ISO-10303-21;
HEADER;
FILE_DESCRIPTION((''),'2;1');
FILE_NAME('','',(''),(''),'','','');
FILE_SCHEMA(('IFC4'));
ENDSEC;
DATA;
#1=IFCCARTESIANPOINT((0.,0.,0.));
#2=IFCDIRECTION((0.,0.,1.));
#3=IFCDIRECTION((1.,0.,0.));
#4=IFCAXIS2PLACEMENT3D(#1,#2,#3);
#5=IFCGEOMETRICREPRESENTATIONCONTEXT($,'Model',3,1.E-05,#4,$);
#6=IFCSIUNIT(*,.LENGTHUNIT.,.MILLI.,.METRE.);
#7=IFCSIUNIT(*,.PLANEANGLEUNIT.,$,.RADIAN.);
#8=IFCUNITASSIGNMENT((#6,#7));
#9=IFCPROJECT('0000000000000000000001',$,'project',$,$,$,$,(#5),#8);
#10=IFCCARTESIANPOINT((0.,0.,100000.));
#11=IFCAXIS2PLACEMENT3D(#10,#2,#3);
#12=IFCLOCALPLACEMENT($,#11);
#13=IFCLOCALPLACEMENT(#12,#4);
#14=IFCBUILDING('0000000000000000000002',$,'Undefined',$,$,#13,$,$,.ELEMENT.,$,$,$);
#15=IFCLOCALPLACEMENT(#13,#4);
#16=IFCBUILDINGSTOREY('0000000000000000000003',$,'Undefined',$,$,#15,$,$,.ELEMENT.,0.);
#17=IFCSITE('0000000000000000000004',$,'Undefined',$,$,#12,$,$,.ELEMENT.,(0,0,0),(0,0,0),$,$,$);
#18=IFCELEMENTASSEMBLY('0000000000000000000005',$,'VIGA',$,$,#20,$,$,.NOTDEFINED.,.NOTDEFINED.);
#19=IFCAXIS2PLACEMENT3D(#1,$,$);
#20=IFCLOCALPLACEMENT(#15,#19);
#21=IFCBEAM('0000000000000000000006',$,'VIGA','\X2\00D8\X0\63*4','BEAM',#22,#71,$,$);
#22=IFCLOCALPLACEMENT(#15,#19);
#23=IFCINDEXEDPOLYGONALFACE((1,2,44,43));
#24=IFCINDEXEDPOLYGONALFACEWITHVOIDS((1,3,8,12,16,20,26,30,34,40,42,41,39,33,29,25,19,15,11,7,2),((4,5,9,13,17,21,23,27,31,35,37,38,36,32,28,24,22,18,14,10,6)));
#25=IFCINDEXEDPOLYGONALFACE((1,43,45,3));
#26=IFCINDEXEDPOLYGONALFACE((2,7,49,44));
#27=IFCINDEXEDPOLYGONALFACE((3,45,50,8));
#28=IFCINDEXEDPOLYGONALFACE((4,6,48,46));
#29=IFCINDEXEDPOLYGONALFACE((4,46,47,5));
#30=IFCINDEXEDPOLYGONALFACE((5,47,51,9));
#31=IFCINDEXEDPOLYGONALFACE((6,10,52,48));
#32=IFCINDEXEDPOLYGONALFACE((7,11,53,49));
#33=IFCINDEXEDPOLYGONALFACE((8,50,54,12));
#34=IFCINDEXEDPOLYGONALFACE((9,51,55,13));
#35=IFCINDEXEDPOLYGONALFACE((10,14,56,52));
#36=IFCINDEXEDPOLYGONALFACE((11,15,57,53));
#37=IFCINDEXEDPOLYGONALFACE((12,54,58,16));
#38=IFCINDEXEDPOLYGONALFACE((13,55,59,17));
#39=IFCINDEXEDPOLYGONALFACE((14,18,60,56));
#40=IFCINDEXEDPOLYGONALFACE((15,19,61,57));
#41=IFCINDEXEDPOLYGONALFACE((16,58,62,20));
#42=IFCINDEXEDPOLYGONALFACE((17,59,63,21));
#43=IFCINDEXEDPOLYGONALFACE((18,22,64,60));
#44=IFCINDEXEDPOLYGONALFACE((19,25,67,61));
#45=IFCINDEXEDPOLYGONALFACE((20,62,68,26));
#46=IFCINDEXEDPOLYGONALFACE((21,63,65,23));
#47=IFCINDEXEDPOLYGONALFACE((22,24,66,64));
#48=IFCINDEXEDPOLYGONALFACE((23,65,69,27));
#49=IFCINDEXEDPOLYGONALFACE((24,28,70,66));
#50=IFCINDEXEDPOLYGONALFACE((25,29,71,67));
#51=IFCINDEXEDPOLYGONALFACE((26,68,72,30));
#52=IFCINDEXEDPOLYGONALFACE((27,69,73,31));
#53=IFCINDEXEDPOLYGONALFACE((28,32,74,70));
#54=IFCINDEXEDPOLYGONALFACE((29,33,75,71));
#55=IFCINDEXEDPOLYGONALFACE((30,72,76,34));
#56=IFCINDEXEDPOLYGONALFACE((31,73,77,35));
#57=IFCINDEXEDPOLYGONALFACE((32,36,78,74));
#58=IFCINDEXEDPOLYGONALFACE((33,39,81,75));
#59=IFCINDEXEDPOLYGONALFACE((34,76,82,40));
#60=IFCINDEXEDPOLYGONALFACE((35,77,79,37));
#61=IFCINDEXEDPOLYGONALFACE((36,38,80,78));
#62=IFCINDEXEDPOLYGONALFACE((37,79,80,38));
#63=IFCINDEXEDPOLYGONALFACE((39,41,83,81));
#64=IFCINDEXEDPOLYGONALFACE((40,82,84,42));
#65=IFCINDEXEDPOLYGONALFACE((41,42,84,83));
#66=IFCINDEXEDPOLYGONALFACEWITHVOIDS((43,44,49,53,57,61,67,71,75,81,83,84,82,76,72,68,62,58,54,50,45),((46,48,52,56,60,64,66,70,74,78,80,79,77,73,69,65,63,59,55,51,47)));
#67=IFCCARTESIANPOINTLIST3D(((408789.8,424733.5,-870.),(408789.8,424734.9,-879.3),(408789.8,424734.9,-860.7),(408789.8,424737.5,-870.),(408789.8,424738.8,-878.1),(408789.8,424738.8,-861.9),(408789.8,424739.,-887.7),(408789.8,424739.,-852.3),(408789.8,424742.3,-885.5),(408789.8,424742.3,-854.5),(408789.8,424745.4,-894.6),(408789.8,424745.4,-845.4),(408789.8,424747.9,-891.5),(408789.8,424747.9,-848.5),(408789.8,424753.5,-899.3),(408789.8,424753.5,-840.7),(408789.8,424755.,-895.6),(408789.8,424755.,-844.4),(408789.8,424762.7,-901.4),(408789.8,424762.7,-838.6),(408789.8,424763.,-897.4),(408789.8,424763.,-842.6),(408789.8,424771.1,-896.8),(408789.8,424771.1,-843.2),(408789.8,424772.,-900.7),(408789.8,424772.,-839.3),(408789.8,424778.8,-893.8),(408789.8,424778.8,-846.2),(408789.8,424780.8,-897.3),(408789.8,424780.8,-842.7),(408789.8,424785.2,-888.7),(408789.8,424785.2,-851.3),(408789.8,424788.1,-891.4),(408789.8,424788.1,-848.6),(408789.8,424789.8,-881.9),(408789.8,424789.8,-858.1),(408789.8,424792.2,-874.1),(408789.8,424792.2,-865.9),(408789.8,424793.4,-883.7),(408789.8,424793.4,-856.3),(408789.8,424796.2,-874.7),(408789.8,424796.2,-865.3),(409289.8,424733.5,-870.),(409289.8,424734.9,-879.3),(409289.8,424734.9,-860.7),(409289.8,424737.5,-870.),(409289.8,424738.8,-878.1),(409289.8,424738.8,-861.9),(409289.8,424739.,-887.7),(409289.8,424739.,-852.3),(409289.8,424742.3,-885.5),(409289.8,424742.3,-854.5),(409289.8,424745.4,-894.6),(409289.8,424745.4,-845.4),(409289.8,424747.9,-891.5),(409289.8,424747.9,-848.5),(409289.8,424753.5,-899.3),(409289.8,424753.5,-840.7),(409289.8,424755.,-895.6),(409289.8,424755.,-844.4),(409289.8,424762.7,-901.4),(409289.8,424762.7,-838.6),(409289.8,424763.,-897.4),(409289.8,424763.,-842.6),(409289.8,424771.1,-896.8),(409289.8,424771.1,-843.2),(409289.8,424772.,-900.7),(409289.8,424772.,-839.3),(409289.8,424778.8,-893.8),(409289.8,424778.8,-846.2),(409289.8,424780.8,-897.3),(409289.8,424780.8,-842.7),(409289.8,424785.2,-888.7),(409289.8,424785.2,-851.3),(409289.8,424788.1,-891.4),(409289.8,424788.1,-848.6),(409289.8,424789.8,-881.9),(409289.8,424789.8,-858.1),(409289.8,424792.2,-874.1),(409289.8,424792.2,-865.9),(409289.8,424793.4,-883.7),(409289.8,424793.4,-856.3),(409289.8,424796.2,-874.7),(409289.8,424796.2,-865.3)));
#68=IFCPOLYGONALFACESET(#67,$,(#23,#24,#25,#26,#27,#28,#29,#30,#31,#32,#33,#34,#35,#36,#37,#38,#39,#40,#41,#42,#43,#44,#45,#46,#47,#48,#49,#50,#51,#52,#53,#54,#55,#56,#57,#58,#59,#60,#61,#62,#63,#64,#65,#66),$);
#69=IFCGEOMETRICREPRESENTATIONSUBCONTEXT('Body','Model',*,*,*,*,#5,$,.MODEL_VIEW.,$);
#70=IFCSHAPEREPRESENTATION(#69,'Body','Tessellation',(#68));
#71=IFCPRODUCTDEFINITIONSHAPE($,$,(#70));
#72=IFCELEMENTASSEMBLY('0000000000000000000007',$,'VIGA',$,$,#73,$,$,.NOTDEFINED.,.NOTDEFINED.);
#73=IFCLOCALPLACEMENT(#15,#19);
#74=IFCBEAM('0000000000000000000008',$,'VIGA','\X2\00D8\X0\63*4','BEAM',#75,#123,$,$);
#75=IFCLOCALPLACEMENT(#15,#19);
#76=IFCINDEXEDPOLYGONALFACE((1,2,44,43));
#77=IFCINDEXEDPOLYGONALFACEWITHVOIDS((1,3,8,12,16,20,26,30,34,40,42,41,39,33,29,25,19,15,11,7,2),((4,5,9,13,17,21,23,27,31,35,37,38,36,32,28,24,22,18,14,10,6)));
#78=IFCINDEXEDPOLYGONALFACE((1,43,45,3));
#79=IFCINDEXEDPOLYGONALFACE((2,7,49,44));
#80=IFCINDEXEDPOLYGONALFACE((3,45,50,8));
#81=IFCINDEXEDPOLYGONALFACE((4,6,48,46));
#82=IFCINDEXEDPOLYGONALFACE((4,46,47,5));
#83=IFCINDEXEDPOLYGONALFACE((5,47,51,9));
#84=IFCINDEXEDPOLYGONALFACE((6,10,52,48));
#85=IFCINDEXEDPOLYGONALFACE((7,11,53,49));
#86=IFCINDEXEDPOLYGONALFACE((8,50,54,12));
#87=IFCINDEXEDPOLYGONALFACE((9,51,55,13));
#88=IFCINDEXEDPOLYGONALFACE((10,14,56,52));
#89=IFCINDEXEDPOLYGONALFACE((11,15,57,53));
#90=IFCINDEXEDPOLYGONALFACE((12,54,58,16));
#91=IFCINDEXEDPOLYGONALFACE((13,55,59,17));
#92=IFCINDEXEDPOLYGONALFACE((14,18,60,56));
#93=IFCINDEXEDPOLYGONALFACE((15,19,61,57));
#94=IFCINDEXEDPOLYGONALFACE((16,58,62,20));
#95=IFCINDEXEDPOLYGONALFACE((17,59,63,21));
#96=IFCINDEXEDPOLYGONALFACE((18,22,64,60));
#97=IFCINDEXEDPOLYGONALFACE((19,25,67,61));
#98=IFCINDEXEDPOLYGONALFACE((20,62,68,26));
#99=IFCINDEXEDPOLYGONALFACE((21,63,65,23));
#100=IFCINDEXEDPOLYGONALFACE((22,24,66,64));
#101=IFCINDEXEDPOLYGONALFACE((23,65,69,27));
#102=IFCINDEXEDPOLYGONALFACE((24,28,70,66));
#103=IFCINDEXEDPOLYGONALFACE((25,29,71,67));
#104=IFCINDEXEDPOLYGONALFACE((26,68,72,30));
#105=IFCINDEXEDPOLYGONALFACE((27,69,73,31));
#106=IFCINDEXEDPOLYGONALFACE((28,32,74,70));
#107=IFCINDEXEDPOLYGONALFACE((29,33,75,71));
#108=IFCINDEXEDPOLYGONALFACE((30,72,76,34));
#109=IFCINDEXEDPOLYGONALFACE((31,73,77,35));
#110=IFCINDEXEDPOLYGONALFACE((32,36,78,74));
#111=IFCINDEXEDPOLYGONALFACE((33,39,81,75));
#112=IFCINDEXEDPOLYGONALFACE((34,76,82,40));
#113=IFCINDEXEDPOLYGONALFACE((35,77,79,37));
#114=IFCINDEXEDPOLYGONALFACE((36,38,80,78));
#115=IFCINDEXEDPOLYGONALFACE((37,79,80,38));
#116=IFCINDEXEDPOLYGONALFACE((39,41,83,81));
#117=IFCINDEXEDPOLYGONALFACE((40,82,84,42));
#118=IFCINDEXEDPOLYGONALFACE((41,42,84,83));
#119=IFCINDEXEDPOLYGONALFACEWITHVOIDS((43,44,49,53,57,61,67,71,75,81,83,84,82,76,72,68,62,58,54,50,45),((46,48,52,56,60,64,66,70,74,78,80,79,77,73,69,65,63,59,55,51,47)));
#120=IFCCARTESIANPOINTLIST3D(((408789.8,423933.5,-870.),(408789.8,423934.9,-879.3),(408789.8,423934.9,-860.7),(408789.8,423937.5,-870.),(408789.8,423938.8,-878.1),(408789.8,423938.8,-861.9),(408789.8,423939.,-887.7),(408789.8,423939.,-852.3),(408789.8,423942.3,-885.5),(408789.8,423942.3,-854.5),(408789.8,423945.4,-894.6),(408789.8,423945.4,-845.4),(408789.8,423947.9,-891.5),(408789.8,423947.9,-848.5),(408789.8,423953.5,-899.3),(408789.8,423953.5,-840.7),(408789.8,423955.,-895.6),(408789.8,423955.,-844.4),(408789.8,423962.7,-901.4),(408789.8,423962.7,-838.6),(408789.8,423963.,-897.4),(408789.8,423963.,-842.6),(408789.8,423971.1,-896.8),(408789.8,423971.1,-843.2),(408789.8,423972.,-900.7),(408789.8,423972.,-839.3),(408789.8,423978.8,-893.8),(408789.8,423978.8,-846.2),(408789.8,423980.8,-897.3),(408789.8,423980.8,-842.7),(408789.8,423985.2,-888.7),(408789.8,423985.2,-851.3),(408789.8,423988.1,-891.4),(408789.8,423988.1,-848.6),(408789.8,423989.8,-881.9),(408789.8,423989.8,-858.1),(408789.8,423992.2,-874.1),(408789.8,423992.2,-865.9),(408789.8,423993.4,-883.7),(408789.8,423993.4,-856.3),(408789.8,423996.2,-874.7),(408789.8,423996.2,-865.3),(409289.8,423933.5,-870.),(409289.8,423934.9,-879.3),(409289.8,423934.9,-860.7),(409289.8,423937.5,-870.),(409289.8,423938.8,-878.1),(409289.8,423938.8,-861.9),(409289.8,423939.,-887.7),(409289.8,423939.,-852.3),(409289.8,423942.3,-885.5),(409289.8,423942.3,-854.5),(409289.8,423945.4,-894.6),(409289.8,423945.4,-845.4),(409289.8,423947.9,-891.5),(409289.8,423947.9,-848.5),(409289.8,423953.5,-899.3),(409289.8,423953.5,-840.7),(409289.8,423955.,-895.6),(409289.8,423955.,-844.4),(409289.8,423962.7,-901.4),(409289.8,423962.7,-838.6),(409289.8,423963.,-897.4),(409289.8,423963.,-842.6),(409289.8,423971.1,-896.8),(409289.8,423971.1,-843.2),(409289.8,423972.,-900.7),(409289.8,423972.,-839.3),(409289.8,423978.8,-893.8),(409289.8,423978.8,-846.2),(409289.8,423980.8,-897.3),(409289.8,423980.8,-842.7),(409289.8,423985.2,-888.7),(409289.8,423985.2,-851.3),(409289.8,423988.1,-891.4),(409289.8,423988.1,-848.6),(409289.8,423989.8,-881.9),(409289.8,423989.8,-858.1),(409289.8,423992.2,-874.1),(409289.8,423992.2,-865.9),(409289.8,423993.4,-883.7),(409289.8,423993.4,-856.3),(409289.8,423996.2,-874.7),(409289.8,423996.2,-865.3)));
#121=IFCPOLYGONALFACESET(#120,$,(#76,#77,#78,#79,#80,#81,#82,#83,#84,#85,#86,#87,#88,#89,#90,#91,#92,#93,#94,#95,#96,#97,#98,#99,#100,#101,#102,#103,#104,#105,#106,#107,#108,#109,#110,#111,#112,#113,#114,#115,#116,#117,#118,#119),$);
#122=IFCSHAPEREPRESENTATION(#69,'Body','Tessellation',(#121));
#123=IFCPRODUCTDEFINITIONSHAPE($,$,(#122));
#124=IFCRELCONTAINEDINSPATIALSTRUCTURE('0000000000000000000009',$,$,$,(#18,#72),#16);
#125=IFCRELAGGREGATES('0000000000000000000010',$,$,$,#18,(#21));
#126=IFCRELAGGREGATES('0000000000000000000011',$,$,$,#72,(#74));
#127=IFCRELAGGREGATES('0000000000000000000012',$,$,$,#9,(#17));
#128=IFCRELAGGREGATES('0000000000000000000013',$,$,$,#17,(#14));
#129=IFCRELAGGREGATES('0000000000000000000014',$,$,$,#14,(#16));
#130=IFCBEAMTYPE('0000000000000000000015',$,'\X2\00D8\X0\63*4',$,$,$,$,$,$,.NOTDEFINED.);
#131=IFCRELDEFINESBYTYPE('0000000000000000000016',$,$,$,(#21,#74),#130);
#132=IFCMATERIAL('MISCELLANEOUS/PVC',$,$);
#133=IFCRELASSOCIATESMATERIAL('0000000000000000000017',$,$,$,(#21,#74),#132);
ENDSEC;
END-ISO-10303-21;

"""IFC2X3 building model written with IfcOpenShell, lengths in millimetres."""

from ifc_helpers import new_model, si_unit, frame, origin_with_axes, origin_2d_with_axis, place, context, subcontext, project, spatial, hollow_circle, extrude, material, type_object, element, aggregate, save


model = new_model("IFC2X3")

# Units and contexts
model_context = context("Model", 3, precision=1e-05, world=origin_with_axes())
body_context = subcontext(model_context, "Body", "Model", "MODEL_VIEW")
ifc_project = project(units=[si_unit("LENGTHUNIT", "METRE", prefix="MILLI"), si_unit("PLANEANGLEUNIT", "RADIAN")], contexts=[model_context])

# Site, building, storey
site_placement = place(None, frame((0.0, 0.0, 100000.0), z_axis=(0.0, 0.0, 1.0), x_axis=(1.0, 0.0, 0.0)))
site = spatial("IfcSite", under=ifc_project, at=site_placement, Name="Undefined", CompositionType="ELEMENT", RefLatitude=(0, 0, 0), RefLongitude=(0, 0, 0))
building_placement = place(site_placement, origin_with_axes())
building = spatial("IfcBuilding", under=site, at=building_placement, Name="Undefined", CompositionType="ELEMENT")
storey_placement = place(building_placement, origin_with_axes())
storey = spatial("IfcBuildingStorey", under=building, at=storey_placement, Name="Undefined", CompositionType="ELEMENT", Elevation=0.0)

# Element assemblies, beams
assembly_1_placement = place(storey_placement, origin_with_axes())
assembly_1 = element("IfcElementAssembly", 1, at=assembly_1_placement, inside=storey, Name="VIGA", AssemblyPlace="NOTDEFINED", PredefinedType="NOTDEFINED")
ifc_material_1 = material(Name="MISCELLANEOUS/PVC")
beam_type_1 = type_object("IfcBeamType", Name="Ø63*4", PredefinedType="NOTDEFINED")
beam_1_placement = place(assembly_1_placement, frame((408789.8, 424765.0, -870.0), z_axis=(0.0, 0.0, 1.0), x_axis=(1.0, 0.0, 0.0)))
beam_1 = element("IfcBeam", 2, at=beam_1_placement, type_object=beam_type_1, material=ifc_material_1, Name="VIGA", Description="Ø63*4", ObjectType="BEAM", context=body_context, shape_type="SweptSolid", body=[
    extrude(hollow_circle(Radius=31.5, WallThickness=4.0, at=origin_2d_with_axis()), frame((500.0, 0.0, 0.0), z_axis=(-1.0, 0.0, 0.0), x_axis=(0.0, -1.0, 0.0)), (0.0, 0.0, 1.0), 500.0),
])
aggregate(assembly_1, [beam_1])
assembly_2_placement = place(storey_placement, origin_with_axes())
assembly_2 = element("IfcElementAssembly", 3, at=assembly_2_placement, inside=storey, Name="VIGA", AssemblyPlace="NOTDEFINED", PredefinedType="NOTDEFINED")
beam_2_placement = place(assembly_2_placement, frame((408789.8, 423965.0, -870.0), z_axis=(0.0, 0.0, 1.0), x_axis=(1.0, 0.0, 0.0)))
beam_2 = element("IfcBeam", 4, at=beam_2_placement, type_object=beam_type_1, material=ifc_material_1, Name="VIGA", Description="Ø63*4", ObjectType="BEAM", context=body_context, shape_type="SweptSolid", body=[
    extrude(hollow_circle(Radius=31.5, WallThickness=4.0, at=origin_2d_with_axis()), frame((500.0, 0.0, 0.0), z_axis=(-1.0, 0.0, 0.0), x_axis=(0.0, -1.0, 0.0)), (0.0, 0.0, 1.0), 500.0),
])
aggregate(assembly_2, [beam_2])

save(model, "model.ifc")
